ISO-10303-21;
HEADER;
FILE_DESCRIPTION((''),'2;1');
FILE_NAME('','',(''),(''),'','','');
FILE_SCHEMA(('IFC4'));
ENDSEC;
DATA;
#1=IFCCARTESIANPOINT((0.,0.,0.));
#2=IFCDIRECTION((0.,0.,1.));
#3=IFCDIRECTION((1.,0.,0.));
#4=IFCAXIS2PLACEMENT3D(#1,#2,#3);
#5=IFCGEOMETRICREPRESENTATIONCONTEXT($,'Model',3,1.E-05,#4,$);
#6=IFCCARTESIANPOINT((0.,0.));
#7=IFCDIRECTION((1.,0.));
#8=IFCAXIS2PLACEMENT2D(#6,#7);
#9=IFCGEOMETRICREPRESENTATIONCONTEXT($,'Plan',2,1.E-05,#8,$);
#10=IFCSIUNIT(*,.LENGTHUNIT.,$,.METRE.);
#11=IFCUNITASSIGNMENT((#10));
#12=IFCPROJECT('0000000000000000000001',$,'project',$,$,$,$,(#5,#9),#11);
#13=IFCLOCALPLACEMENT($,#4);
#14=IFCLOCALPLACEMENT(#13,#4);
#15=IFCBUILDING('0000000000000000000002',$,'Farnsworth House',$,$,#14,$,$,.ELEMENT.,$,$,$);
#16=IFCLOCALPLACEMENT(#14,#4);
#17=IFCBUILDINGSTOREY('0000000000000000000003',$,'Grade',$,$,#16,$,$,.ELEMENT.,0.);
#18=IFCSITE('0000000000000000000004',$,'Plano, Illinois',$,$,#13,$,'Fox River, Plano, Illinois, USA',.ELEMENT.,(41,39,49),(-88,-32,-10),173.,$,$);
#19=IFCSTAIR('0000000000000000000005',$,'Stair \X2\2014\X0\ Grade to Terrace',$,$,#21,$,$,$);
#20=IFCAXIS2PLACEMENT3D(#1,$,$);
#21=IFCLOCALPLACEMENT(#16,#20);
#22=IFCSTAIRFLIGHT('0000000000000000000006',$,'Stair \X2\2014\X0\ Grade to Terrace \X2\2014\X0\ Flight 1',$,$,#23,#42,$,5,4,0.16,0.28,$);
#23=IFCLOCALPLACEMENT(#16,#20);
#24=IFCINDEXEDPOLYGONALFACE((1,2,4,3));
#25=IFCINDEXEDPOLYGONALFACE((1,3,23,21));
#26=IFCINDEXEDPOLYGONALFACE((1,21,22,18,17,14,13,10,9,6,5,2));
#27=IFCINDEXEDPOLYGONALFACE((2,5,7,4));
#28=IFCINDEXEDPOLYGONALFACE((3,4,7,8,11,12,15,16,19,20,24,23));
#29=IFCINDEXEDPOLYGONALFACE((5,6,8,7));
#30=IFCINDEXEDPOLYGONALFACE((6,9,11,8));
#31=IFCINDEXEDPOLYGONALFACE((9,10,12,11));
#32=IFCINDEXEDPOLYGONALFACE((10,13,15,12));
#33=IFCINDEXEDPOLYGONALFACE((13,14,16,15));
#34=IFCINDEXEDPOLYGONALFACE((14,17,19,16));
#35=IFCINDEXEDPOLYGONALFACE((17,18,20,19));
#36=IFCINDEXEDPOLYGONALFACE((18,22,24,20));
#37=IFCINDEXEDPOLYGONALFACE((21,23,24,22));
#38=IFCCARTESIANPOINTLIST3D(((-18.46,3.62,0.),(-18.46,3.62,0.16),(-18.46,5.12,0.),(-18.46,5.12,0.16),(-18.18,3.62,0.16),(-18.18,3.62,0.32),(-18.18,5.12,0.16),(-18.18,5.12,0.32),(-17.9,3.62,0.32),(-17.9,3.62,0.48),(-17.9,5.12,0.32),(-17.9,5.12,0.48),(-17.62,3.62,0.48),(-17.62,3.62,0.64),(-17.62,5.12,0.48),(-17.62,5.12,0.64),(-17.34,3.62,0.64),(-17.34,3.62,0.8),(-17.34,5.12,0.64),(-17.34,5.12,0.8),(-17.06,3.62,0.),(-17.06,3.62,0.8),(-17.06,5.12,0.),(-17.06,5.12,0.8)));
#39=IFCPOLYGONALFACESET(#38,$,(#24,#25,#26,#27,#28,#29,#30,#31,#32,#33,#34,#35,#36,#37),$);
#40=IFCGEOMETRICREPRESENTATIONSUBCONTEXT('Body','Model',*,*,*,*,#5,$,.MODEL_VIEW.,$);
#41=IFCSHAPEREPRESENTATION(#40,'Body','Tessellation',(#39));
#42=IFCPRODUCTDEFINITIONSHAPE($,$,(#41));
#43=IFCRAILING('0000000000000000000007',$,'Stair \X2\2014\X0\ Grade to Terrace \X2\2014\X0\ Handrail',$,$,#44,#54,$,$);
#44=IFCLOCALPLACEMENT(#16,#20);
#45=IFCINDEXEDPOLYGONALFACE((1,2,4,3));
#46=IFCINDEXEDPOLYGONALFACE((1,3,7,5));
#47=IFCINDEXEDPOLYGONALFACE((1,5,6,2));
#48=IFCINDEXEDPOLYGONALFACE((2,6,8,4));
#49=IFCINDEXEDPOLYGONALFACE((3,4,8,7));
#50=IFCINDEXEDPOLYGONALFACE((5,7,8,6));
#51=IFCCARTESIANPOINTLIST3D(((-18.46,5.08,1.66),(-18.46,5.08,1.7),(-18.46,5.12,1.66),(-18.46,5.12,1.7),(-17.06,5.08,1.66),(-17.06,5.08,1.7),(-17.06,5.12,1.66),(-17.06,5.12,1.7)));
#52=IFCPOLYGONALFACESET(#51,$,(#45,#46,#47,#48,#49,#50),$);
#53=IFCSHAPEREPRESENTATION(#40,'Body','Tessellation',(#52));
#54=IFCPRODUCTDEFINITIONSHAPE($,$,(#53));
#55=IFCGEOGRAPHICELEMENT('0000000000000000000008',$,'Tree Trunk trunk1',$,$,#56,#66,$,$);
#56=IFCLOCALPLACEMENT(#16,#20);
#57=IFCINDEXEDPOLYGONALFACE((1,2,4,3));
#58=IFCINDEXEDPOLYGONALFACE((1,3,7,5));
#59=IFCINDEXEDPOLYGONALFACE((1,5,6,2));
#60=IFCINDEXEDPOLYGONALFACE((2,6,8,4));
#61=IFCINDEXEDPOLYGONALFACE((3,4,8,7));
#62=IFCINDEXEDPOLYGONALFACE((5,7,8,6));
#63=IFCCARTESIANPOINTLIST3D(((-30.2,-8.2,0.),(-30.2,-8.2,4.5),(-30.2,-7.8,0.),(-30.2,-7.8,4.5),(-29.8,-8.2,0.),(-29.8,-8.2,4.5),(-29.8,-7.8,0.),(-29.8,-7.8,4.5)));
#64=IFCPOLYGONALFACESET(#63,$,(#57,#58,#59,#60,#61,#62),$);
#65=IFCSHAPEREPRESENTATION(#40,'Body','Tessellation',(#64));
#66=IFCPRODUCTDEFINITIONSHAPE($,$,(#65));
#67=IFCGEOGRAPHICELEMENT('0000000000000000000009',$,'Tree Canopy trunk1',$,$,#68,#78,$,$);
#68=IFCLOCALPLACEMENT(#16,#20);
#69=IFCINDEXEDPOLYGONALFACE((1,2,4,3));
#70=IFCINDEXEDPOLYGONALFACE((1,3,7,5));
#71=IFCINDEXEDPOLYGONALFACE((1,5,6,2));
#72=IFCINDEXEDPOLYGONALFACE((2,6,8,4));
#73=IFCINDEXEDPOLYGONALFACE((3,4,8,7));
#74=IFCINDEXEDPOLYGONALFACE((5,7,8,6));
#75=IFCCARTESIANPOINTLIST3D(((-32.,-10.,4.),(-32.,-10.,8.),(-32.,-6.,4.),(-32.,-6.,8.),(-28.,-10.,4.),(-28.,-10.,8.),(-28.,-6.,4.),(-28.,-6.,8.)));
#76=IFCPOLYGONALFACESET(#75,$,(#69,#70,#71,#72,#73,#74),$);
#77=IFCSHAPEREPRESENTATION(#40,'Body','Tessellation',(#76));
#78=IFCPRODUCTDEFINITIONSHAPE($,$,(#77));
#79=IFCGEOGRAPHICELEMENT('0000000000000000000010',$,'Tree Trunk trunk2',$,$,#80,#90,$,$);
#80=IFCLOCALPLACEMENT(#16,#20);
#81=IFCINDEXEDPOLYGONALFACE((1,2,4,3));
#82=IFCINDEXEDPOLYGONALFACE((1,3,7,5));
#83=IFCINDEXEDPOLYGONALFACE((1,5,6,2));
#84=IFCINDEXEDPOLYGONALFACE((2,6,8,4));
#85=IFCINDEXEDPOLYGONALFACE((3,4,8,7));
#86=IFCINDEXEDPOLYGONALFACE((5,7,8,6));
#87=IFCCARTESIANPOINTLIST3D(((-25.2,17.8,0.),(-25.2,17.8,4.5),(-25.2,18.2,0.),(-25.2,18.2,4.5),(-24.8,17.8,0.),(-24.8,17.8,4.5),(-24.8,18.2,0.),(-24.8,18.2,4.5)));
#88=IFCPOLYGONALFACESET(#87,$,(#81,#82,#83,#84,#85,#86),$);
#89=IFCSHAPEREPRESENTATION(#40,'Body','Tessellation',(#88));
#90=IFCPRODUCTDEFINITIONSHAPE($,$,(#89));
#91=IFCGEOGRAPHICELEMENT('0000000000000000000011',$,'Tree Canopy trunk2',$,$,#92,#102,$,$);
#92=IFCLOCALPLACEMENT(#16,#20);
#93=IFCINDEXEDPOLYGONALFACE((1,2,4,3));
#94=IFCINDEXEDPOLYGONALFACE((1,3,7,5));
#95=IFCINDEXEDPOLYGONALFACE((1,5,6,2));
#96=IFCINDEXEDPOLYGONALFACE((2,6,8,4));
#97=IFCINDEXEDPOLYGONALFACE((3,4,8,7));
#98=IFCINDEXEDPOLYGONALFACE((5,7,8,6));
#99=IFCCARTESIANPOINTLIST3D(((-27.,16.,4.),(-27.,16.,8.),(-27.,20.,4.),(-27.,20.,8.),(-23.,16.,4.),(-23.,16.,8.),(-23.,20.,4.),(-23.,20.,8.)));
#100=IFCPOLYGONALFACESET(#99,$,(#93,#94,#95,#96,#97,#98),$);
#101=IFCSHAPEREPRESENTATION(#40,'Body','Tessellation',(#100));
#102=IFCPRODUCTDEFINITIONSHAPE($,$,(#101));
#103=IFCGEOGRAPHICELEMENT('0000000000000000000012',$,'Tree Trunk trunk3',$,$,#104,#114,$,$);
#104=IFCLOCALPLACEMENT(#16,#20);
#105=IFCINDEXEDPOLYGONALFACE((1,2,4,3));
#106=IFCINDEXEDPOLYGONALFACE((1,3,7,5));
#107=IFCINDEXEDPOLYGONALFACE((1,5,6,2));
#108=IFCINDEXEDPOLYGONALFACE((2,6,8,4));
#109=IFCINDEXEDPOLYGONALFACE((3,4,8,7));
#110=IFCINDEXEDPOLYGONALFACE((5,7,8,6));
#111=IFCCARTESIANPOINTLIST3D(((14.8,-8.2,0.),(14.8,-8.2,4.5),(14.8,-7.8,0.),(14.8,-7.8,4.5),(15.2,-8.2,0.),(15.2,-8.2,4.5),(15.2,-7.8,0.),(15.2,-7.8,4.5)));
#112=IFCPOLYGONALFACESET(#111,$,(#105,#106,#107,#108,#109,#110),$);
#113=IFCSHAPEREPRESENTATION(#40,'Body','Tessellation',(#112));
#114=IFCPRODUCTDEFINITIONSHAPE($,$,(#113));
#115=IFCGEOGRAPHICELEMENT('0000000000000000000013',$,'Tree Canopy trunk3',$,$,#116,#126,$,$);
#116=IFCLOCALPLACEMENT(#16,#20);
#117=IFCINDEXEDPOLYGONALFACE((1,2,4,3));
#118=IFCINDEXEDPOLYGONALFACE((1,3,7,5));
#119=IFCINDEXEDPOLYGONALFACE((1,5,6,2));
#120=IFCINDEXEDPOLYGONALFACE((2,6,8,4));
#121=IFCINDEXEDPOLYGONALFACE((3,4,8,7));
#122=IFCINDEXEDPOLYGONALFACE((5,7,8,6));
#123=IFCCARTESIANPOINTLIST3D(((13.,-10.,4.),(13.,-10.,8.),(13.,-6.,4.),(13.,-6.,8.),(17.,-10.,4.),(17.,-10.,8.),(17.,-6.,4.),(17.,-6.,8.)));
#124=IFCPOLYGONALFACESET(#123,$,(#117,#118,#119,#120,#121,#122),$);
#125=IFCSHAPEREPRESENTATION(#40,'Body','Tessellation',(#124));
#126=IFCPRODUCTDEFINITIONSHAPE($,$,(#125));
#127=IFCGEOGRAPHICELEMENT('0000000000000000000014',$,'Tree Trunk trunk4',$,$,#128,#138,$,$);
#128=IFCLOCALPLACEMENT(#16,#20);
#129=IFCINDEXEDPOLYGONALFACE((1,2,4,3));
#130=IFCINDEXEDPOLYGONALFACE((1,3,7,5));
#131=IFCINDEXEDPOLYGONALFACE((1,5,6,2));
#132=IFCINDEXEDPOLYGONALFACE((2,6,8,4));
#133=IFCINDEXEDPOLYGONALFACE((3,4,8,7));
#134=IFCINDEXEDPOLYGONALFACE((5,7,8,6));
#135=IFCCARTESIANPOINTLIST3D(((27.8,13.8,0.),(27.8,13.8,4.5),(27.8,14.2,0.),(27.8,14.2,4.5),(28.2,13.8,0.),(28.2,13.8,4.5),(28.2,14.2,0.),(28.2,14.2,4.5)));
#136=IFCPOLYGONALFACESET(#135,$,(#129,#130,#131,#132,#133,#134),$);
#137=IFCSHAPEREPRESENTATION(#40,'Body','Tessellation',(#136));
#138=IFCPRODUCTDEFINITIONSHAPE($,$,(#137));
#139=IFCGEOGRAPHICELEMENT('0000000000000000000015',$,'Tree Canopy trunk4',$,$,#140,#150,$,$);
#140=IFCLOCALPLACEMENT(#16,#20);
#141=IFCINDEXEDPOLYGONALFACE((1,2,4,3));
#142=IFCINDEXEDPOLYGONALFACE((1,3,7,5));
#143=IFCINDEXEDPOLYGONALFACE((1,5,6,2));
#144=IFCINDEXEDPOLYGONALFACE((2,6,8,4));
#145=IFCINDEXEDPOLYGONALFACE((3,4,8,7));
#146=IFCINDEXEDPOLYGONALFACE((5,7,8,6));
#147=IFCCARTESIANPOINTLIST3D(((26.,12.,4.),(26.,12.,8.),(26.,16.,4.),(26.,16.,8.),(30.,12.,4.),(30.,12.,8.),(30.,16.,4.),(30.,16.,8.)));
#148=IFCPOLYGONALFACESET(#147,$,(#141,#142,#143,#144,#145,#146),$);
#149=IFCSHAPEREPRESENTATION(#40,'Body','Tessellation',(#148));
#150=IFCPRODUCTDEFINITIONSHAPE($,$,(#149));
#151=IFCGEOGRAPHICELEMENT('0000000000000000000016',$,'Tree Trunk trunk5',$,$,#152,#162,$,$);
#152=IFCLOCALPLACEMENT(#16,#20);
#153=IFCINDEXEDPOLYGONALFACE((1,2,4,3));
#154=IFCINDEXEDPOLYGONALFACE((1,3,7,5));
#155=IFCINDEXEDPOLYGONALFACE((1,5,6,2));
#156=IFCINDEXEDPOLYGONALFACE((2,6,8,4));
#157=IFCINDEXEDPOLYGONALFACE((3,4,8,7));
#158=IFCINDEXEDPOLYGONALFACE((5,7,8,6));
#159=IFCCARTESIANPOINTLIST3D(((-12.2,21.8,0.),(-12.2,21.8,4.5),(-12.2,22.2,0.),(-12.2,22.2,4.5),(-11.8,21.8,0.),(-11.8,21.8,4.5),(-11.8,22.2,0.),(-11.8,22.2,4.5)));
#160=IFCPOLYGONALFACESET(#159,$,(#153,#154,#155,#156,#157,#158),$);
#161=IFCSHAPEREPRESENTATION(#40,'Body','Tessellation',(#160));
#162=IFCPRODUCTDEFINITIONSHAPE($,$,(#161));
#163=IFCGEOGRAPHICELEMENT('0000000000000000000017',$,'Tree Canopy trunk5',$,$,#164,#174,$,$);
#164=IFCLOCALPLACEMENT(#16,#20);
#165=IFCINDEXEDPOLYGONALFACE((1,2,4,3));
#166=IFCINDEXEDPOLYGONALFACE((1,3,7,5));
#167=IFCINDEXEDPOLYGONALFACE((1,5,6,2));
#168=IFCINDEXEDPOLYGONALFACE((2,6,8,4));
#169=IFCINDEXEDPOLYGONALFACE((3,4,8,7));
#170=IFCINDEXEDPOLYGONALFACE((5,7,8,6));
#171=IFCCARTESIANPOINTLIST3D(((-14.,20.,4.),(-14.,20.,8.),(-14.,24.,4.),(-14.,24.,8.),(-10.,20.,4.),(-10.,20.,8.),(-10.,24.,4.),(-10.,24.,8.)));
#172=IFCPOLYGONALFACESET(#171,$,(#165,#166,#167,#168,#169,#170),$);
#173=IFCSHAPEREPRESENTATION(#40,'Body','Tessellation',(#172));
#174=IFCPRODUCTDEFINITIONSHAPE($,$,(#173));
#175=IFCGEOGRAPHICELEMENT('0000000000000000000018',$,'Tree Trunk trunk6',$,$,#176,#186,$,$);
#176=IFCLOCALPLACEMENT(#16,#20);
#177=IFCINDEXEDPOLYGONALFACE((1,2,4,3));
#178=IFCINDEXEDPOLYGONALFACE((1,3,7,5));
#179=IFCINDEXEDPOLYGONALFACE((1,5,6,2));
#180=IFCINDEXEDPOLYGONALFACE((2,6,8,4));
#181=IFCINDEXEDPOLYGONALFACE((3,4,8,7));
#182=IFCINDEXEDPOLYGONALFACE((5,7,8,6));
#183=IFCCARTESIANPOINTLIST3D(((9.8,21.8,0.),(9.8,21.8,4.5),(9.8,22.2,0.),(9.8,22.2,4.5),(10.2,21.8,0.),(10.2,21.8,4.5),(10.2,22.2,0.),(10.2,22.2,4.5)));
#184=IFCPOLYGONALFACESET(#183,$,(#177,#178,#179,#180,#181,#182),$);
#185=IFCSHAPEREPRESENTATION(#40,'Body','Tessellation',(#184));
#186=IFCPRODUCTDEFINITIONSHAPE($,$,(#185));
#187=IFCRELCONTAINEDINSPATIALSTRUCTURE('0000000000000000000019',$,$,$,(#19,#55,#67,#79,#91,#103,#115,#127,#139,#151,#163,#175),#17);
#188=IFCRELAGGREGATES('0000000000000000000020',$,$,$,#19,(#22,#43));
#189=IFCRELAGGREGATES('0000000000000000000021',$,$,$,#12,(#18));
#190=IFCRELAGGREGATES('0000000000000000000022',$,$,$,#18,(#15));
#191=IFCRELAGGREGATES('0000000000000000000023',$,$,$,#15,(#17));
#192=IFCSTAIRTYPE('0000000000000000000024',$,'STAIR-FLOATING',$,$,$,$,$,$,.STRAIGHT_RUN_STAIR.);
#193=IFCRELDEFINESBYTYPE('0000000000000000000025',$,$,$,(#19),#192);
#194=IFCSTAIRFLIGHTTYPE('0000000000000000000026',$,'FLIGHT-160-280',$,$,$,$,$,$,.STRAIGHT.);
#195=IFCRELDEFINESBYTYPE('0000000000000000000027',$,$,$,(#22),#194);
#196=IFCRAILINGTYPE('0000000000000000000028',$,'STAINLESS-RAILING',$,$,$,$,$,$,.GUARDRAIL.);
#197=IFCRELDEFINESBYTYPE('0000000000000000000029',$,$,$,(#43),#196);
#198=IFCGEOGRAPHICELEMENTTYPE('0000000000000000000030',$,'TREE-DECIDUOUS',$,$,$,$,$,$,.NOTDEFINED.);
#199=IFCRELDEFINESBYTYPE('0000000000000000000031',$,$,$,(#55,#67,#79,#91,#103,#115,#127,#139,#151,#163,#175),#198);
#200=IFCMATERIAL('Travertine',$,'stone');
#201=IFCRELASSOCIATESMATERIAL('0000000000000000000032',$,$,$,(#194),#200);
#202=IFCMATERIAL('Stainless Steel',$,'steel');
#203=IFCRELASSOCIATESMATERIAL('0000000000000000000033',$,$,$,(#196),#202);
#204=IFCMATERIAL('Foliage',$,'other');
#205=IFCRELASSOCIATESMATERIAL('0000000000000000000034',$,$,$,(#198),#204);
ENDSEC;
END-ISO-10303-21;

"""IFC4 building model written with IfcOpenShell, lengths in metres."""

from ifc_helpers import new_model, si_unit, frame, origin_with_axes, origin_2d_with_axis, place, context, subcontext, project, spatial, polyline, rectangle, outline, extrude, material, type_object, element, aggregate, save


model = new_model("IFC4")

# Units and contexts
model_context = context("Model", 3, precision=1e-05, world=origin_with_axes())
plan_context = context("Plan", 2, precision=1e-05, world=origin_2d_with_axis())
body_context = subcontext(model_context, "Body", "Model", "MODEL_VIEW")
ifc_project = project(units=[si_unit("LENGTHUNIT", "METRE")], contexts=[model_context, plan_context])

# Site, building, storey
site_placement = place(None, origin_with_axes())
site = spatial("IfcSite", under=ifc_project, at=site_placement, Name="Plano, Illinois", LongName="Fox River, Plano, Illinois, USA", CompositionType="ELEMENT", RefLatitude=(41, 39, 49), RefLongitude=(-88, -32, -10), RefElevation=173.0)
building_placement = place(site_placement, origin_with_axes())
building = spatial("IfcBuilding", under=site, at=building_placement, Name="Farnsworth House", CompositionType="ELEMENT")
storey_placement = place(building_placement, origin_with_axes())
storey = spatial("IfcBuildingStorey", under=building, at=storey_placement, Name="Grade", CompositionType="ELEMENT", Elevation=0.0)

# Stair, stair flight, railing
stair_type = type_object("IfcStairType", Name="STAIR-FLOATING", PredefinedType="STRAIGHT_RUN_STAIR")
stair_placement = place(storey_placement, frame((-18.46, 3.62, 0.0), z_axis=(0.0, 0.0, 1.0), x_axis=(1.0, 0.0, 0.0)))
stair = element("IfcStair", 1, at=stair_placement, inside=storey, type_object=stair_type, Name="Stair — Grade to Terrace")
ifc_material_1 = material(Name="Travertine", Category="stone")
stair_flight_type = type_object("IfcStairFlightType", Name="FLIGHT-160-280", PredefinedType="STRAIGHT", material=ifc_material_1)
stair_flight_placement = place(stair_placement, origin_with_axes())
stair_flight = element("IfcStairFlight", 2, at=stair_flight_placement, type_object=stair_flight_type, Name="Stair — Grade to Terrace — Flight 1", NumberOfRisers=5, NumberOfTreads=4, RiserHeight=0.16, TreadLength=0.28, context=body_context, shape_type="SweptSolid", body=[
    extrude(outline(polyline([(0.0, 0.0), (0.0, 0.16), (0.28, 0.16), (0.28, 0.32), (0.56, 0.32), (0.56, 0.48), (0.84, 0.48), (0.84, 0.64), (1.12, 0.64), (1.12, 0.8), (1.4, 0.8), (1.4, 0.0), (0.0, 0.0)])), frame((0.0, 0.0, 0.0), z_axis=(0.0, -1.0, 0.0), x_axis=(1.0, 0.0, 0.0)), (0.0, 0.0, -1.0), 1.5),
])
ifc_material_2 = material(Name="Stainless Steel", Category="steel")
railing_type = type_object("IfcRailingType", Name="STAINLESS-RAILING", PredefinedType="GUARDRAIL", material=ifc_material_2)
railing_placement = place(stair_placement, frame((0.0, 1.46, 1.66), z_axis=(0.0, 0.0, 1.0), x_axis=(1.0, 0.0, 0.0)))
railing = element("IfcRailing", 3, at=railing_placement, type_object=railing_type, Name="Stair — Grade to Terrace — Handrail", context=body_context, shape_type="SweptSolid", body=[
    extrude(rectangle(XDim=1.4, YDim=0.04, at=origin_2d_with_axis()), frame((0.7, 0.02, 0.0), z_axis=(0.0, 0.0, 1.0), x_axis=(1.0, 0.0, 0.0)), (0.0, 0.0, 1.0), 0.04),
])
aggregate(stair, [stair_flight, railing])

# Geographic elements
ifc_material_3 = material(Name="Foliage", Category="other")
geographic_element_type = type_object("IfcGeographicElementType", Name="TREE-DECIDUOUS", PredefinedType="NOTDEFINED", material=ifc_material_3)
geographic_element_1_placement = place(storey_placement, frame((-30.2, -8.2, 0.0), z_axis=(0.0, 0.0, 1.0), x_axis=(1.0, 0.0, 0.0)))
element("IfcGeographicElement", 4, at=geographic_element_1_placement, inside=storey, type_object=geographic_element_type, Name="Tree Trunk trunk1", context=body_context, shape_type="SweptSolid", body=[
    extrude(rectangle(XDim=0.4, YDim=0.4, at=origin_2d_with_axis()), frame((0.2, 0.2, 0.0), z_axis=(0.0, 0.0, 1.0), x_axis=(1.0, 0.0, 0.0)), (0.0, 0.0, 1.0), 4.5),
])
geographic_element_2_placement = place(storey_placement, frame((-32.0, -10.0, 4.0), z_axis=(0.0, 0.0, 1.0), x_axis=(1.0, 0.0, 0.0)))
element("IfcGeographicElement", 5, at=geographic_element_2_placement, inside=storey, type_object=geographic_element_type, Name="Tree Canopy trunk1", context=body_context, shape_type="SweptSolid", body=[
    extrude(rectangle(XDim=4.0, YDim=4.0, at=origin_2d_with_axis()), frame((2.0, 2.0, 0.0), z_axis=(0.0, 0.0, 1.0), x_axis=(1.0, 0.0, 0.0)), (0.0, 0.0, 1.0), 4.0),
])
geographic_element_3_placement = place(storey_placement, frame((-25.2, 17.8, 0.0), z_axis=(0.0, 0.0, 1.0), x_axis=(1.0, 0.0, 0.0)))
element("IfcGeographicElement", 6, at=geographic_element_3_placement, inside=storey, type_object=geographic_element_type, Name="Tree Trunk trunk2", context=body_context, shape_type="SweptSolid", body=[
    extrude(rectangle(XDim=0.4, YDim=0.4, at=origin_2d_with_axis()), frame((0.2, 0.2, 0.0), z_axis=(0.0, 0.0, 1.0), x_axis=(1.0, 0.0, 0.0)), (0.0, 0.0, 1.0), 4.5),
])
geographic_element_4_placement = place(storey_placement, frame((-27.0, 16.0, 4.0), z_axis=(0.0, 0.0, 1.0), x_axis=(1.0, 0.0, 0.0)))
element("IfcGeographicElement", 7, at=geographic_element_4_placement, inside=storey, type_object=geographic_element_type, Name="Tree Canopy trunk2", context=body_context, shape_type="SweptSolid", body=[
    extrude(rectangle(XDim=4.0, YDim=4.0, at=origin_2d_with_axis()), frame((2.0, 2.0, 0.0), z_axis=(0.0, 0.0, 1.0), x_axis=(1.0, 0.0, 0.0)), (0.0, 0.0, 1.0), 4.0),
])
geographic_element_5_placement = place(storey_placement, frame((14.8, -8.2, 0.0), z_axis=(0.0, 0.0, 1.0), x_axis=(1.0, 0.0, 0.0)))
element("IfcGeographicElement", 8, at=geographic_element_5_placement, inside=storey, type_object=geographic_element_type, Name="Tree Trunk trunk3", context=body_context, shape_type="SweptSolid", body=[
    extrude(rectangle(XDim=0.4, YDim=0.4, at=origin_2d_with_axis()), frame((0.2, 0.2, 0.0), z_axis=(0.0, 0.0, 1.0), x_axis=(1.0, 0.0, 0.0)), (0.0, 0.0, 1.0), 4.5),
])
geographic_element_6_placement = place(storey_placement, frame((13.0, -10.0, 4.0), z_axis=(0.0, 0.0, 1.0), x_axis=(1.0, 0.0, 0.0)))
element("IfcGeographicElement", 9, at=geographic_element_6_placement, inside=storey, type_object=geographic_element_type, Name="Tree Canopy trunk3", context=body_context, shape_type="SweptSolid", body=[
    extrude(rectangle(XDim=4.0, YDim=4.0, at=origin_2d_with_axis()), frame((2.0, 2.0, 0.0), z_axis=(0.0, 0.0, 1.0), x_axis=(1.0, 0.0, 0.0)), (0.0, 0.0, 1.0), 4.0),
])
geographic_element_7_placement = place(storey_placement, frame((27.8, 13.8, 0.0), z_axis=(0.0, 0.0, 1.0), x_axis=(1.0, 0.0, 0.0)))
element("IfcGeographicElement", 10, at=geographic_element_7_placement, inside=storey, type_object=geographic_element_type, Name="Tree Trunk trunk4", context=body_context, shape_type="SweptSolid", body=[
    extrude(rectangle(XDim=0.4, YDim=0.4, at=origin_2d_with_axis()), frame((0.2, 0.2, 0.0), z_axis=(0.0, 0.0, 1.0), x_axis=(1.0, 0.0, 0.0)), (0.0, 0.0, 1.0), 4.5),
])
geographic_element_8_placement = place(storey_placement, frame((26.0, 12.0, 4.0), z_axis=(0.0, 0.0, 1.0), x_axis=(1.0, 0.0, 0.0)))
element("IfcGeographicElement", 11, at=geographic_element_8_placement, inside=storey, type_object=geographic_element_type, Name="Tree Canopy trunk4", context=body_context, shape_type="SweptSolid", body=[
    extrude(rectangle(XDim=4.0, YDim=4.0, at=origin_2d_with_axis()), frame((2.0, 2.0, 0.0), z_axis=(0.0, 0.0, 1.0), x_axis=(1.0, 0.0, 0.0)), (0.0, 0.0, 1.0), 4.0),
])
geographic_element_9_placement = place(storey_placement, frame((-12.2, 21.8, 0.0), z_axis=(0.0, 0.0, 1.0), x_axis=(1.0, 0.0, 0.0)))
element("IfcGeographicElement", 12, at=geographic_element_9_placement, inside=storey, type_object=geographic_element_type, Name="Tree Trunk trunk5", context=body_context, shape_type="SweptSolid", body=[
    extrude(rectangle(XDim=0.4, YDim=0.4, at=origin_2d_with_axis()), frame((0.2, 0.2, 0.0), z_axis=(0.0, 0.0, 1.0), x_axis=(1.0, 0.0, 0.0)), (0.0, 0.0, 1.0), 4.5),
])
geographic_element_10_placement = place(storey_placement, frame((-14.0, 20.0, 4.0), z_axis=(0.0, 0.0, 1.0), x_axis=(1.0, 0.0, 0.0)))
element("IfcGeographicElement", 13, at=geographic_element_10_placement, inside=storey, type_object=geographic_element_type, Name="Tree Canopy trunk5", context=body_context, shape_type="SweptSolid", body=[
    extrude(rectangle(XDim=4.0, YDim=4.0, at=origin_2d_with_axis()), frame((2.0, 2.0, 0.0), z_axis=(0.0, 0.0, 1.0), x_axis=(1.0, 0.0, 0.0)), (0.0, 0.0, 1.0), 4.0),
])
geographic_element_11_placement = place(storey_placement, frame((9.8, 21.8, 0.0), z_axis=(0.0, 0.0, 1.0), x_axis=(1.0, 0.0, 0.0)))
element("IfcGeographicElement", 14, at=geographic_element_11_placement, inside=storey, type_object=geographic_element_type, Name="Tree Trunk trunk6", context=body_context, shape_type="SweptSolid", body=[
    extrude(rectangle(XDim=0.4, YDim=0.4, at=origin_2d_with_axis()), frame((0.2, 0.2, 0.0), z_axis=(0.0, 0.0, 1.0), x_axis=(1.0, 0.0, 0.0)), (0.0, 0.0, 1.0), 4.5),
])

save(model, "model.ifc")
